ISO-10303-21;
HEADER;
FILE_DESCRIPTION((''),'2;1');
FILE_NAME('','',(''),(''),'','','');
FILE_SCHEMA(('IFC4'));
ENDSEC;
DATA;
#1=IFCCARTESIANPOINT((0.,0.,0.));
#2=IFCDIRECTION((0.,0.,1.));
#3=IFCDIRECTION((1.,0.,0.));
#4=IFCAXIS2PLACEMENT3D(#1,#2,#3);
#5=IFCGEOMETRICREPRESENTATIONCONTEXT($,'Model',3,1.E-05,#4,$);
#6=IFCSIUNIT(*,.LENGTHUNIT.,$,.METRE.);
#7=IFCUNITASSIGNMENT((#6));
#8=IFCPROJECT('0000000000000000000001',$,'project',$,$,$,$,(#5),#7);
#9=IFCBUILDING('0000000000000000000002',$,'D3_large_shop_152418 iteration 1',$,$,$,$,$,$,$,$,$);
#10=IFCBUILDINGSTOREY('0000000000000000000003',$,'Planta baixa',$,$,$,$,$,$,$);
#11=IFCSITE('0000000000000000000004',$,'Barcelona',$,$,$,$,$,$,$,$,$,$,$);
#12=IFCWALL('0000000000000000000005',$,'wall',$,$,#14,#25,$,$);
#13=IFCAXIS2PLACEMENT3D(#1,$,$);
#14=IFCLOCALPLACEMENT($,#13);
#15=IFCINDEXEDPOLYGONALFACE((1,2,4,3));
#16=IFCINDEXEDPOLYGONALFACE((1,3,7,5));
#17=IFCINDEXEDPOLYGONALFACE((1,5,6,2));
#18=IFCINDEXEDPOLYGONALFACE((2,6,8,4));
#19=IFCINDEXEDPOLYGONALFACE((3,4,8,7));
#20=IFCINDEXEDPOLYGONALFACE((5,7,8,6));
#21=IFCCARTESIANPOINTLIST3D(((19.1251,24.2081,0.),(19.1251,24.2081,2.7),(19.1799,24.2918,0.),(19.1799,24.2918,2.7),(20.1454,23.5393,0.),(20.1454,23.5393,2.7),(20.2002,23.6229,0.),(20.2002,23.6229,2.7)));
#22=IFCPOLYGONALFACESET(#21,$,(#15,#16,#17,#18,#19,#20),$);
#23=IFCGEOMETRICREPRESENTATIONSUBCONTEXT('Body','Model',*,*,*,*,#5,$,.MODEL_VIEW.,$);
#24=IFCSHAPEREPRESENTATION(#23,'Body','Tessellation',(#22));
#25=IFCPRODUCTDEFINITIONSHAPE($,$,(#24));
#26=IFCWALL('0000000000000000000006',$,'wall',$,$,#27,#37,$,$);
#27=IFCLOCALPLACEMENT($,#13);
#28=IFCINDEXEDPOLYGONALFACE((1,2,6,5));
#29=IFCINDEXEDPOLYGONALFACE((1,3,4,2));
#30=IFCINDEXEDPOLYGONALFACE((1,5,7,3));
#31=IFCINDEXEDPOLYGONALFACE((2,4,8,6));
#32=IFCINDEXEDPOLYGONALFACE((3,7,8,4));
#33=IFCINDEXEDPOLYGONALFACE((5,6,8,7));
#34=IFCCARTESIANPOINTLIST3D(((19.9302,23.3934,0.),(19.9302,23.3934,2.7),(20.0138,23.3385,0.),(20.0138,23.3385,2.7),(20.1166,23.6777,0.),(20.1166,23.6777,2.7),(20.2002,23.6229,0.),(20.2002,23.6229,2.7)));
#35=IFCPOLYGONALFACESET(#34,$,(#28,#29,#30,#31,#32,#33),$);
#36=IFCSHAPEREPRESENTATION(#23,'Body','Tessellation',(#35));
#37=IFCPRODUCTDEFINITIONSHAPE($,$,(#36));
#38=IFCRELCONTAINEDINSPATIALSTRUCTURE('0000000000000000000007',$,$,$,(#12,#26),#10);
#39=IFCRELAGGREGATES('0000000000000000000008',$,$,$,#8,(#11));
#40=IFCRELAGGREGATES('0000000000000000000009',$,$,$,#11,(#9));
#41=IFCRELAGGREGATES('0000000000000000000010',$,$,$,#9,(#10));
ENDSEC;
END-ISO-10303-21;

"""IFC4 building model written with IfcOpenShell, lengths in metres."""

from ifc_helpers import new_model, si_unit, origin, origin_with_axes, place, context, subcontext, project, spatial, polyline, outline, extrude, element, save


model = new_model("IFC4")

# Units and contexts
model_context = context("Model", 3, precision=1e-05, world=origin_with_axes())
body_context = subcontext(model_context, "Body", "Model", "MODEL_VIEW")
ifc_project = project(units=[si_unit("LENGTHUNIT", "METRE")], contexts=[model_context])

# Site, building, storey
site = spatial("IfcSite", under=ifc_project, Name="Barcelona")
building = spatial("IfcBuilding", under=site, Name="D3_large_shop_152418 iteration 1")
storey = spatial("IfcBuildingStorey", under=building, Name="Planta baixa")

# Walls
wall_1_placement = place(None, origin_with_axes())
element("IfcWall", 1, at=wall_1_placement, inside=storey, Name="wall", context=body_context, shape_type="SweptSolid", body=[
    extrude(outline(polyline([(19.1799, 24.2918), (20.2002, 23.6229), (20.1454, 23.5393), (19.1251, 24.2081), (19.1799, 24.2918)])), origin(), (0.0, 0.0, 1.0), 2.7),
])
wall_2_placement = place(None, origin_with_axes())
element("IfcWall", 2, at=wall_2_placement, inside=storey, Name="wall", context=body_context, shape_type="SweptSolid", body=[
    extrude(outline(polyline([(20.2002, 23.6229), (20.0138, 23.3385), (19.9302, 23.3934), (20.1166, 23.6777), (20.2002, 23.6229)])), origin(), (0.0, 0.0, 1.0), 2.7),
])

save(model, "model.ifc")
